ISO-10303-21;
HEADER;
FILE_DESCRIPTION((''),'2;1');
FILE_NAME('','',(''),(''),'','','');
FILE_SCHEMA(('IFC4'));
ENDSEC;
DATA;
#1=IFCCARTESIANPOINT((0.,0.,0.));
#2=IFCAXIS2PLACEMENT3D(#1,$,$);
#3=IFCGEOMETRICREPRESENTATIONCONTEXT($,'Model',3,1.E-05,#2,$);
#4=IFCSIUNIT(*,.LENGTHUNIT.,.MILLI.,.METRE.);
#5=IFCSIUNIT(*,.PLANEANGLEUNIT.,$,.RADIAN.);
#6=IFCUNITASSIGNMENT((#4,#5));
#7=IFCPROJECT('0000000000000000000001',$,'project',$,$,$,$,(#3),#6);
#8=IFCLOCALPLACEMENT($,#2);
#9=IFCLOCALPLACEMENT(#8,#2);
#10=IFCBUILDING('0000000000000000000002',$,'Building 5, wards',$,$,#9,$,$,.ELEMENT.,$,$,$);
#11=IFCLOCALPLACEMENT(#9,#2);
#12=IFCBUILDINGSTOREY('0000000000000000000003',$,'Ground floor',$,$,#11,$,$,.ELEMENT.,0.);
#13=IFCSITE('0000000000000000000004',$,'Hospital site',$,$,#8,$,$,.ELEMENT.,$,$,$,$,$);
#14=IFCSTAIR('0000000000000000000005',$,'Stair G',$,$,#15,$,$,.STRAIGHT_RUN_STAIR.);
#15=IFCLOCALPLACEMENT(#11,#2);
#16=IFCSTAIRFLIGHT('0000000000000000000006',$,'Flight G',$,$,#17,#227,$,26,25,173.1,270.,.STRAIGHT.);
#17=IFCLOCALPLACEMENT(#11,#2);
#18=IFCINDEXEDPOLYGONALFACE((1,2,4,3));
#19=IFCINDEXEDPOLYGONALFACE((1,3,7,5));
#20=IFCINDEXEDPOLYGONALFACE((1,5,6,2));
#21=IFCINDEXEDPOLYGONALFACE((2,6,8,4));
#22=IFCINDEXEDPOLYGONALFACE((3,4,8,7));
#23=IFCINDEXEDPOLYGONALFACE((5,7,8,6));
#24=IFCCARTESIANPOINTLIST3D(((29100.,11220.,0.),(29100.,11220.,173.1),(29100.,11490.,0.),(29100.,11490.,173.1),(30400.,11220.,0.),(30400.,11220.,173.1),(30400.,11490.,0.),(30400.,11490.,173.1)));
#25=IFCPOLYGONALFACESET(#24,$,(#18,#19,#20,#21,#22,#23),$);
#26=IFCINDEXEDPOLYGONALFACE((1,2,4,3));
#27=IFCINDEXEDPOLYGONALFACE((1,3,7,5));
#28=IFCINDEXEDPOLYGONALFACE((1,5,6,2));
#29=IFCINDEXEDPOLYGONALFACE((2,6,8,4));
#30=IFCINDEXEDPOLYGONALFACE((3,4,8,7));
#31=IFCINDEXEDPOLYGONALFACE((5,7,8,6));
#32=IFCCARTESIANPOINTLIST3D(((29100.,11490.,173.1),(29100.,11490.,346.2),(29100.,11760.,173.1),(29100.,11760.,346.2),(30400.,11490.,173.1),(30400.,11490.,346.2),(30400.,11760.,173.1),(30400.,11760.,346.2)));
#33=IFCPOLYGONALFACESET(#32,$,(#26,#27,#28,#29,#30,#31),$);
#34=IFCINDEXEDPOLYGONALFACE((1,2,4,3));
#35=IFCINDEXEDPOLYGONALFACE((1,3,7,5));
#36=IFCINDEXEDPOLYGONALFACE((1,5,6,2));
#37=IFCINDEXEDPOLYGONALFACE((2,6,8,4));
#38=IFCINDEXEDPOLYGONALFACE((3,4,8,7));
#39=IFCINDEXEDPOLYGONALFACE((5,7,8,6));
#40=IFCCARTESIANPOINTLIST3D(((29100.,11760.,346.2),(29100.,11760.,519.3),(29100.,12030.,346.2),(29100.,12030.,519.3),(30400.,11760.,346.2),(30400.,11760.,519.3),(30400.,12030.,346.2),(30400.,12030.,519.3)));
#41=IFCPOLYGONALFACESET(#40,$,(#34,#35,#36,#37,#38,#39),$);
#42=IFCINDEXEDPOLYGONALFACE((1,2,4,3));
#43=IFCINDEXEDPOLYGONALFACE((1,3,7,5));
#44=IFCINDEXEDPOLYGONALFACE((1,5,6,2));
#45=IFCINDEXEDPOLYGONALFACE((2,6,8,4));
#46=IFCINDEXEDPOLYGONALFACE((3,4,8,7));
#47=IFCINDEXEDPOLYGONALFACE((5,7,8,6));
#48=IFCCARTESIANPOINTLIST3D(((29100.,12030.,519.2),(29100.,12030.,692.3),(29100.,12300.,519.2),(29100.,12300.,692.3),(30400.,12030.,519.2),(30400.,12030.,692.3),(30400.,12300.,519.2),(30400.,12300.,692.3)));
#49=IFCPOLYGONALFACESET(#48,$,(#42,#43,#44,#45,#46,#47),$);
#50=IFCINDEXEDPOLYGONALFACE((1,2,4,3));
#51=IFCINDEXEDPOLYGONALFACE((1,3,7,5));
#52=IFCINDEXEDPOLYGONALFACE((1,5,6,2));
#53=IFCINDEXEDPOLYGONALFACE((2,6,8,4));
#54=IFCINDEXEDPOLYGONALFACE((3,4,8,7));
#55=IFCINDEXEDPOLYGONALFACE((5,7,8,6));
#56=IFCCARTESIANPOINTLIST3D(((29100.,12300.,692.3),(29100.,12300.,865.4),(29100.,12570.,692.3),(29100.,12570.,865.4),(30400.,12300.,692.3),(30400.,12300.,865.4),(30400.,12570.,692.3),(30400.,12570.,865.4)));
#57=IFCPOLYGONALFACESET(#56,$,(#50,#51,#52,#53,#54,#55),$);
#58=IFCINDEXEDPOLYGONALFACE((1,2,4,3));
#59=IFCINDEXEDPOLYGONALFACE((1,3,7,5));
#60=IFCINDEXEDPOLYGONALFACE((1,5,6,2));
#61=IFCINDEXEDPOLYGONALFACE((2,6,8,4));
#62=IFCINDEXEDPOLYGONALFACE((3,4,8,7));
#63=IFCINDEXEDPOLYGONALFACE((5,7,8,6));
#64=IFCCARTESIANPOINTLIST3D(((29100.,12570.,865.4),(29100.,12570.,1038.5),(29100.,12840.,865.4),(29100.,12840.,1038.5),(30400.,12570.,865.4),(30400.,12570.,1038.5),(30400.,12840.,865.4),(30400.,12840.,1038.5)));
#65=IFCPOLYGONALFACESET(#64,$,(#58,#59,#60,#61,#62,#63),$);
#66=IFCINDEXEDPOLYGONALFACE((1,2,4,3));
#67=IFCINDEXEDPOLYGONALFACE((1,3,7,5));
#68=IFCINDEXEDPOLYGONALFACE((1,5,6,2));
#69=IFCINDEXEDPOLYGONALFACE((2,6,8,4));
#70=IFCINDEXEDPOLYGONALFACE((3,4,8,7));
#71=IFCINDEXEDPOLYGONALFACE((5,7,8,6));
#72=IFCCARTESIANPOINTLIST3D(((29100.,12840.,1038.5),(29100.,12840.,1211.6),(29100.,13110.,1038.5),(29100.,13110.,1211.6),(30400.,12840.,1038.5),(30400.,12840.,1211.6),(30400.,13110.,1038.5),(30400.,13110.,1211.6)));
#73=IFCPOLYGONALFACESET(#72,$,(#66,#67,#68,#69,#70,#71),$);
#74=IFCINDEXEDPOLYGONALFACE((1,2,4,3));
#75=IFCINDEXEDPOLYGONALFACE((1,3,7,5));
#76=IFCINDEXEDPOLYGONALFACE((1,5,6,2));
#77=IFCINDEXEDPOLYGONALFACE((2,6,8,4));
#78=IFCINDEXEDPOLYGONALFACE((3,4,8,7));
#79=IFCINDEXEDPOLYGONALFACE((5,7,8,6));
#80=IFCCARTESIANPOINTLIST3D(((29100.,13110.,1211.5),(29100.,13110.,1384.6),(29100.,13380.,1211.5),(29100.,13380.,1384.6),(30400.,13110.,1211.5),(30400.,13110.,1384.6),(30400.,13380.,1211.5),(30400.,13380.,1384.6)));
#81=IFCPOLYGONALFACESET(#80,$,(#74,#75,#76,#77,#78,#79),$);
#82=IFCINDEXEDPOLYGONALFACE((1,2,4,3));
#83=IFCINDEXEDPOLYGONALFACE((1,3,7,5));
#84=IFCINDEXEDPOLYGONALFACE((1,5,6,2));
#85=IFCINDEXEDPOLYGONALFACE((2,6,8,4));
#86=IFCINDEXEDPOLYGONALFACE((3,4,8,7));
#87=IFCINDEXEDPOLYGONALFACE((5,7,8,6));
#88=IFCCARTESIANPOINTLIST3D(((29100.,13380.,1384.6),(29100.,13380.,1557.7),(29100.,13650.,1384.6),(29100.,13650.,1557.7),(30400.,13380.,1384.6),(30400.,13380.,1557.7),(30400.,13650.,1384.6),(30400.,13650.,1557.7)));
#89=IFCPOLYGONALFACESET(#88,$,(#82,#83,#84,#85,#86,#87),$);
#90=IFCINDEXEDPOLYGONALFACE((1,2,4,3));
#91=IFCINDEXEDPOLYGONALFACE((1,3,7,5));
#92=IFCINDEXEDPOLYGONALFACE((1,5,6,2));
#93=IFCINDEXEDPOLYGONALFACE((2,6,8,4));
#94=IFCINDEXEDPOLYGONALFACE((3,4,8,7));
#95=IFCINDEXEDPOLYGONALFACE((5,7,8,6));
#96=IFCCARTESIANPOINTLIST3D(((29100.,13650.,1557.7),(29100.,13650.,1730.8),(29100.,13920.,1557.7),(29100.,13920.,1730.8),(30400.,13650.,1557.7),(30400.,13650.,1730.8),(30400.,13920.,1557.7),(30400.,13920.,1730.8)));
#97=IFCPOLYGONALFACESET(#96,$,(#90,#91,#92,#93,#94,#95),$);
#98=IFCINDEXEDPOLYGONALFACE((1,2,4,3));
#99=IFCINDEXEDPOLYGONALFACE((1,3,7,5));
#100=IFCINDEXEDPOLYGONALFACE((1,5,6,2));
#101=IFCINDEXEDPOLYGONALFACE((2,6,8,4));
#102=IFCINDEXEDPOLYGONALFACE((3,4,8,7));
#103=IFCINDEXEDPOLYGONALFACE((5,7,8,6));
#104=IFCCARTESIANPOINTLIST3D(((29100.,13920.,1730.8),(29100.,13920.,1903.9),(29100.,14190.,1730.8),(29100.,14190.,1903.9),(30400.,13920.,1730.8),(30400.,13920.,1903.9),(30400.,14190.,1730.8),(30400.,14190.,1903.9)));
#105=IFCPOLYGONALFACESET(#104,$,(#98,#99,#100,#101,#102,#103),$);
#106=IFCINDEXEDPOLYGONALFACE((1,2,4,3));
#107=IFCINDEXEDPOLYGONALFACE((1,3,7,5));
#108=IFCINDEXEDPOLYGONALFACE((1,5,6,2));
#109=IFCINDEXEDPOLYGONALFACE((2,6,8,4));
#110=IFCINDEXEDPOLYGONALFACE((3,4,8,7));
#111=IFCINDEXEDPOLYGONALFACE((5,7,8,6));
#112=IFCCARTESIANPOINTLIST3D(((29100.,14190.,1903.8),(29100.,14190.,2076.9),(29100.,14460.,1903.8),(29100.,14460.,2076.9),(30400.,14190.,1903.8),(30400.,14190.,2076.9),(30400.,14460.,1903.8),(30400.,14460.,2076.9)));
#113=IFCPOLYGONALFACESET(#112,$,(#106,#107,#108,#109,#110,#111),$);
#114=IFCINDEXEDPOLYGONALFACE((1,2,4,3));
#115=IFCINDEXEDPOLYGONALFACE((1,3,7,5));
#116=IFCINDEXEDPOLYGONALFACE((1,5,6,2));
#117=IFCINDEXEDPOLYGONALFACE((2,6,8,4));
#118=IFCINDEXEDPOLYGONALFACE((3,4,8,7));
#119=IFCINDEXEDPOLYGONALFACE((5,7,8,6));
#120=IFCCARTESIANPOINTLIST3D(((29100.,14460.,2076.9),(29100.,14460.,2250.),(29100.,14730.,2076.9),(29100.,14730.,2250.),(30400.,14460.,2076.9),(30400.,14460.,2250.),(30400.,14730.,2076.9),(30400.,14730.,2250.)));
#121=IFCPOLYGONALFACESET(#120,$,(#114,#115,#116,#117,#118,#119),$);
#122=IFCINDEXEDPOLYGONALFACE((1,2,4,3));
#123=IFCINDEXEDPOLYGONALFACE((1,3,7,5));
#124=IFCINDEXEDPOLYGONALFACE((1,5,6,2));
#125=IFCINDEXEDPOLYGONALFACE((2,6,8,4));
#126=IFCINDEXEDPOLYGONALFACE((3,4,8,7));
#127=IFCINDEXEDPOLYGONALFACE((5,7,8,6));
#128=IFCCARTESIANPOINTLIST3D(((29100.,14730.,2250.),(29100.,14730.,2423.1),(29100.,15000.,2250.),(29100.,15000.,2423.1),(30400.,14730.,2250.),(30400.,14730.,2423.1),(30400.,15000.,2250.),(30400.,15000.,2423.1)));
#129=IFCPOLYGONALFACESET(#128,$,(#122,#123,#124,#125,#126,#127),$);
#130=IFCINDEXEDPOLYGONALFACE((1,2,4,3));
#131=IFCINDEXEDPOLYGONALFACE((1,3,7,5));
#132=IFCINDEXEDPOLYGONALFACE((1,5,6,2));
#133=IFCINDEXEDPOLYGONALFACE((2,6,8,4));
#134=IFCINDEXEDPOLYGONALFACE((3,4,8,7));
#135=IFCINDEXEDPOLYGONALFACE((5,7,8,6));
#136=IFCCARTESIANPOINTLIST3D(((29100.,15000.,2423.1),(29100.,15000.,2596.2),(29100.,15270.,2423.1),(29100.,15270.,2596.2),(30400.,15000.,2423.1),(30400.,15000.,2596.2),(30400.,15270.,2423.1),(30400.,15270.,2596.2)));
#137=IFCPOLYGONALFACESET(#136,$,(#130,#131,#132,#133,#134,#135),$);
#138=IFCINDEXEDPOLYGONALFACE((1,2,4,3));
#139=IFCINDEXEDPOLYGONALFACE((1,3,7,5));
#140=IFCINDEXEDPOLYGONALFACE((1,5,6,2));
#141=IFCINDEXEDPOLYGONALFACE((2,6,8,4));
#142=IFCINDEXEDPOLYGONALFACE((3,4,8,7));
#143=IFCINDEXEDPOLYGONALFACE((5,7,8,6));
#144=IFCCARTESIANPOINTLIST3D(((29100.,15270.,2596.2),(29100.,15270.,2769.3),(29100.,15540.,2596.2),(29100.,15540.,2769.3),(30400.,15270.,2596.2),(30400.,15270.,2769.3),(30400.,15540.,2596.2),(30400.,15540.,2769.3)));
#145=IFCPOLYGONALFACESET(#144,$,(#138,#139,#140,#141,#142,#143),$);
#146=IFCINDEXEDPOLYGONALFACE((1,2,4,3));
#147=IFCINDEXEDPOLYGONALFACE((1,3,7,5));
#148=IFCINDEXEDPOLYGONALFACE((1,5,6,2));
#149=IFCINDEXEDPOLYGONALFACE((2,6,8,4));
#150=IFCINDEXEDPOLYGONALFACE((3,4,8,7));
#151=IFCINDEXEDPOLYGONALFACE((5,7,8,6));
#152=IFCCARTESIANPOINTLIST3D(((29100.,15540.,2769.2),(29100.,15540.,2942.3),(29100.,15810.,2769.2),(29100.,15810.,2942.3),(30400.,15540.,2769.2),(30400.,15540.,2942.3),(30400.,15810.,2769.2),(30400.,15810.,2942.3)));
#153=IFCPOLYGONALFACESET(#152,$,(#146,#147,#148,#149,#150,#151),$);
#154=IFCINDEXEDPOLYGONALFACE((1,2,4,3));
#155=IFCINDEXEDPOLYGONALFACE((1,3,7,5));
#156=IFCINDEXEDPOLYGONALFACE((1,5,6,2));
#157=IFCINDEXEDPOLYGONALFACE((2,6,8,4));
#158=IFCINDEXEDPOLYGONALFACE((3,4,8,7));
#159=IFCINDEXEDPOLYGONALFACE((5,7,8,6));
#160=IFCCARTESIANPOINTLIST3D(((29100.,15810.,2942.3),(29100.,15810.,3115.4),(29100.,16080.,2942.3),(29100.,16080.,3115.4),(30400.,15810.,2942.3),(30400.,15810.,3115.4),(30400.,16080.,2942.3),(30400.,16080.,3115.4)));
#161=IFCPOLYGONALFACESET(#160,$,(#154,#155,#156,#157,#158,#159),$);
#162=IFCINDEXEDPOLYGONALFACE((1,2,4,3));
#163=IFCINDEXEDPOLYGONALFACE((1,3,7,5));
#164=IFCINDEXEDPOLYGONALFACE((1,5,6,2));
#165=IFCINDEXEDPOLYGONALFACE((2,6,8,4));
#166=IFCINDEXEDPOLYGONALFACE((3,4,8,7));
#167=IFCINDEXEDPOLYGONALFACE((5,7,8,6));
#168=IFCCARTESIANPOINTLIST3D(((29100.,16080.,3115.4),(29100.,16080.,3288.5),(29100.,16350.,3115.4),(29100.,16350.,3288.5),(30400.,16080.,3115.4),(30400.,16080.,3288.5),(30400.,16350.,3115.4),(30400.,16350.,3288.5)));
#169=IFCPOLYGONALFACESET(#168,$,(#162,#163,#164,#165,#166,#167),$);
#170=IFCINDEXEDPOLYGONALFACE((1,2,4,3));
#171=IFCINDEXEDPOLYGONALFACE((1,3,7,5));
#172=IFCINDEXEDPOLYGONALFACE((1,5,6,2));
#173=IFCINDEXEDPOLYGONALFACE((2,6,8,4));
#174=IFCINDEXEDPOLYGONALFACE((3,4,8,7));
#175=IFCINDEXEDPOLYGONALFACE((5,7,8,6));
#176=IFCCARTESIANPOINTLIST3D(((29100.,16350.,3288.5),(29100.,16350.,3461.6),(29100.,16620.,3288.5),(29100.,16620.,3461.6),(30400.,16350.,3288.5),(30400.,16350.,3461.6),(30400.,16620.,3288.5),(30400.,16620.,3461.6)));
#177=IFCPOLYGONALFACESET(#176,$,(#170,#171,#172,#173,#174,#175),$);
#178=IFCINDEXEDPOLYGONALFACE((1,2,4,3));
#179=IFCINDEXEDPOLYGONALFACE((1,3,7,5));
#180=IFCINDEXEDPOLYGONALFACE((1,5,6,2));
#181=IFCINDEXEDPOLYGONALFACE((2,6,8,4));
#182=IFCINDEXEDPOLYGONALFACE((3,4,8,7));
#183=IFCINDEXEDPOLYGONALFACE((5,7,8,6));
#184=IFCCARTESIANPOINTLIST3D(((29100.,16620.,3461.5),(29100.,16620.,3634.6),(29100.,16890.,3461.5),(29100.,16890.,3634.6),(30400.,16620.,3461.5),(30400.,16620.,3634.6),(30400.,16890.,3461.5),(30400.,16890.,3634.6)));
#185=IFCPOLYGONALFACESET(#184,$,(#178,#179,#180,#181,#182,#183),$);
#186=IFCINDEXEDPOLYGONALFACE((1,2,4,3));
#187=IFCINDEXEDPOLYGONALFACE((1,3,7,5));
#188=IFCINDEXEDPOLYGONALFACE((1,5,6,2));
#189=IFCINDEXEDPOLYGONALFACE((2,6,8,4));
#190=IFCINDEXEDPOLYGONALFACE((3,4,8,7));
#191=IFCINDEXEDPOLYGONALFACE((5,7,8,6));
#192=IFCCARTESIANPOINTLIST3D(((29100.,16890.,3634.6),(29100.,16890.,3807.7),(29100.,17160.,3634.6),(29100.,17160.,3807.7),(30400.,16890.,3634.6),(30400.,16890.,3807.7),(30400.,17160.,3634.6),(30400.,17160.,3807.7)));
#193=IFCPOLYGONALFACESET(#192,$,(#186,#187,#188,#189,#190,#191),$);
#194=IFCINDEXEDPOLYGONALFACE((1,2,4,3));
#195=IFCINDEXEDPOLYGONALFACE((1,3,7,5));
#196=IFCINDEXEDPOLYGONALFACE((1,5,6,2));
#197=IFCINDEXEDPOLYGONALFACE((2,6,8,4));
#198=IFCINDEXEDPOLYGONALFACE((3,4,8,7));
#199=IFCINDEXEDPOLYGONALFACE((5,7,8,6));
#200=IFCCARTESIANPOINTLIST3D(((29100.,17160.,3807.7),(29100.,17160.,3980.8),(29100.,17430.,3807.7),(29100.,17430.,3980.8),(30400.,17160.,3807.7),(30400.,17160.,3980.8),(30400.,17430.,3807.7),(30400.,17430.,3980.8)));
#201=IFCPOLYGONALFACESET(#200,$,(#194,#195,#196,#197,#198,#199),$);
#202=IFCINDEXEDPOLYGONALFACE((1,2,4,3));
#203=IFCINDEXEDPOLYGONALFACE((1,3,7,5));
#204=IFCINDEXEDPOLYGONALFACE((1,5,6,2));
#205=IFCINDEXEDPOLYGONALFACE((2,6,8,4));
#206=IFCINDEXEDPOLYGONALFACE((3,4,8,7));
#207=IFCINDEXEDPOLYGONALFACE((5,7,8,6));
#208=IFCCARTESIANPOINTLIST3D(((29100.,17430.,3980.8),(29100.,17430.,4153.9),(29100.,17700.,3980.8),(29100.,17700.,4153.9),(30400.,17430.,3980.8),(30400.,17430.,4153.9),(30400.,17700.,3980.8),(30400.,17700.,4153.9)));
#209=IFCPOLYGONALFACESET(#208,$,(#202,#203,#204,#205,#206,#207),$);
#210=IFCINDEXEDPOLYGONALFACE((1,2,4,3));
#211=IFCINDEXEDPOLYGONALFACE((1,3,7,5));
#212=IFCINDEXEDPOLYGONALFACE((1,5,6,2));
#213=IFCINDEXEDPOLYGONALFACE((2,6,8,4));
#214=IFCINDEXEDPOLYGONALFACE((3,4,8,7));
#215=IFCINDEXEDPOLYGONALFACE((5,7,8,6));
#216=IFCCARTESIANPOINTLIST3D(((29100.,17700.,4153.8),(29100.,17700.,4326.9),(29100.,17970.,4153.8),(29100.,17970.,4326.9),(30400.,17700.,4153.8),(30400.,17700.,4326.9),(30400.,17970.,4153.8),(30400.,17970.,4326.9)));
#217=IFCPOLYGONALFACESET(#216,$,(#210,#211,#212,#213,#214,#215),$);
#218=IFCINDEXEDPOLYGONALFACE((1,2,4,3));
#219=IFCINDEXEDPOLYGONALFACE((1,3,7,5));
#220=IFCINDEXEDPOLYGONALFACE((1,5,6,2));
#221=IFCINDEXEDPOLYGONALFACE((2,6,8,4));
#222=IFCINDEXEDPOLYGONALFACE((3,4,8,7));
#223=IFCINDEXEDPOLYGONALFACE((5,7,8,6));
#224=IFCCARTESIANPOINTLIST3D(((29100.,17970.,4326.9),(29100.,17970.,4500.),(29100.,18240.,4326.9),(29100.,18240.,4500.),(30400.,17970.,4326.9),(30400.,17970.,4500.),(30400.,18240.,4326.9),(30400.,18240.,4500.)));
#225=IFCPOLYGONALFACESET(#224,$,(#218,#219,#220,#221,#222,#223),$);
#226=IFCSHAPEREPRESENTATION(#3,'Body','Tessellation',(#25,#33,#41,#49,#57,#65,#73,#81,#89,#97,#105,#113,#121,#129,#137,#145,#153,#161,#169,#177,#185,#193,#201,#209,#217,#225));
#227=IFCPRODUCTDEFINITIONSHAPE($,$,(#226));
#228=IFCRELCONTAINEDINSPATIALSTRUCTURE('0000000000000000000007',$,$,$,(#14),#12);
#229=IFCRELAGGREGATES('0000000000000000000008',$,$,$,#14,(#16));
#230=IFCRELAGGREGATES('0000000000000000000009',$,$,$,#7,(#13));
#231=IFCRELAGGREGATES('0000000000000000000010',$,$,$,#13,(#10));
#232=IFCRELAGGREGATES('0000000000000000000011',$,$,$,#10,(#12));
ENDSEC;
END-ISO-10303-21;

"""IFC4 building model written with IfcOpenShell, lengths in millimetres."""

from ifc_helpers import new_model, si_unit, frame, frame_2d, origin, place, context, project, spatial, rectangle, extrude, element, aggregate, save


model = new_model("IFC4")

# Units and contexts
model_context = context("Model", 3, precision=1e-05, world=origin())
ifc_project = project(units=[si_unit("LENGTHUNIT", "METRE", prefix="MILLI"), si_unit("PLANEANGLEUNIT", "RADIAN")], contexts=[model_context])

# Site, building, storey
site_placement = place(None, origin())
site = spatial("IfcSite", under=ifc_project, at=site_placement, Name="Hospital site", CompositionType="ELEMENT")
building_placement = place(site_placement, origin())
building = spatial("IfcBuilding", under=site, at=building_placement, Name="Building 5, wards", CompositionType="ELEMENT")
storey_placement = place(building_placement, origin())
storey = spatial("IfcBuildingStorey", under=building, at=storey_placement, Name="Ground floor", CompositionType="ELEMENT", Elevation=0.0)

# Stair, stair flight
stair_placement = place(storey_placement, origin())
stair = element("IfcStair", 1, at=stair_placement, inside=storey, Name="Stair G", PredefinedType="STRAIGHT_RUN_STAIR")
stair_flight_placement = place(storey_placement, frame((29100.0, 11220.0, 0.0)))
stair_flight = element("IfcStairFlight", 2, at=stair_flight_placement, Name="Flight G", NumberOfRisers=26, NumberOfTreads=25, PredefinedType="STRAIGHT", RiserHeight=173.1, TreadLength=270.0, context=model_context, shape_type="SweptSolid", body=[
    extrude(rectangle(XDim=1300.0, YDim=270.0, at=frame_2d((650.0, 135.0))), origin(), (0.0, 0.0, 1.0), 173.1),
    extrude(rectangle(XDim=1300.0, YDim=270.0, at=frame_2d((650.0, 405.0))), frame((0.0, 0.0, 173.1)), (0.0, 0.0, 1.0), 173.1),
    extrude(rectangle(XDim=1300.0, YDim=270.0, at=frame_2d((650.0, 675.0))), frame((0.0, 0.0, 346.2)), (0.0, 0.0, 1.0), 173.1),
    extrude(rectangle(XDim=1300.0, YDim=270.0, at=frame_2d((650.0, 945.0))), frame((0.0, 0.0, 519.2)), (0.0, 0.0, 1.0), 173.1),
    extrude(rectangle(XDim=1300.0, YDim=270.0, at=frame_2d((650.0, 1215.0))), frame((0.0, 0.0, 692.3)), (0.0, 0.0, 1.0), 173.1),
    extrude(rectangle(XDim=1300.0, YDim=270.0, at=frame_2d((650.0, 1485.0))), frame((0.0, 0.0, 865.4)), (0.0, 0.0, 1.0), 173.1),
    extrude(rectangle(XDim=1300.0, YDim=270.0, at=frame_2d((650.0, 1755.0))), frame((0.0, 0.0, 1038.5)), (0.0, 0.0, 1.0), 173.1),
    extrude(rectangle(XDim=1300.0, YDim=270.0, at=frame_2d((650.0, 2025.0))), frame((0.0, 0.0, 1211.5)), (0.0, 0.0, 1.0), 173.1),
    extrude(rectangle(XDim=1300.0, YDim=270.0, at=frame_2d((650.0, 2295.0))), frame((0.0, 0.0, 1384.6)), (0.0, 0.0, 1.0), 173.1),
    extrude(rectangle(XDim=1300.0, YDim=270.0, at=frame_2d((650.0, 2565.0))), frame((0.0, 0.0, 1557.7)), (0.0, 0.0, 1.0), 173.1),
    extrude(rectangle(XDim=1300.0, YDim=270.0, at=frame_2d((650.0, 2835.0))), frame((0.0, 0.0, 1730.8)), (0.0, 0.0, 1.0), 173.1),
    extrude(rectangle(XDim=1300.0, YDim=270.0, at=frame_2d((650.0, 3105.0))), frame((0.0, 0.0, 1903.8)), (0.0, 0.0, 1.0), 173.1),
    extrude(rectangle(XDim=1300.0, YDim=270.0, at=frame_2d((650.0, 3375.0))), frame((0.0, 0.0, 2076.9)), (0.0, 0.0, 1.0), 173.1),
    extrude(rectangle(XDim=1300.0, YDim=270.0, at=frame_2d((650.0, 3645.0))), frame((0.0, 0.0, 2250.0)), (0.0, 0.0, 1.0), 173.1),
    extrude(rectangle(XDim=1300.0, YDim=270.0, at=frame_2d((650.0, 3915.0))), frame((0.0, 0.0, 2423.1)), (0.0, 0.0, 1.0), 173.1),
    extrude(rectangle(XDim=1300.0, YDim=270.0, at=frame_2d((650.0, 4185.0))), frame((0.0, 0.0, 2596.2)), (0.0, 0.0, 1.0), 173.1),
    extrude(rectangle(XDim=1300.0, YDim=270.0, at=frame_2d((650.0, 4455.0))), frame((0.0, 0.0, 2769.2)), (0.0, 0.0, 1.0), 173.1),
    extrude(rectangle(XDim=1300.0, YDim=270.0, at=frame_2d((650.0, 4725.0))), frame((0.0, 0.0, 2942.3)), (0.0, 0.0, 1.0), 173.1),
    extrude(rectangle(XDim=1300.0, YDim=270.0, at=frame_2d((650.0, 4995.0))), frame((0.0, 0.0, 3115.4)), (0.0, 0.0, 1.0), 173.1),
    extrude(rectangle(XDim=1300.0, YDim=270.0, at=frame_2d((650.0, 5265.0))), frame((0.0, 0.0, 3288.5)), (0.0, 0.0, 1.0), 173.1),
    extrude(rectangle(XDim=1300.0, YDim=270.0, at=frame_2d((650.0, 5535.0))), frame((0.0, 0.0, 3461.5)), (0.0, 0.0, 1.0), 173.1),
    extrude(rectangle(XDim=1300.0, YDim=270.0, at=frame_2d((650.0, 5805.0))), frame((0.0, 0.0, 3634.6)), (0.0, 0.0, 1.0), 173.1),
    extrude(rectangle(XDim=1300.0, YDim=270.0, at=frame_2d((650.0, 6075.0))), frame((0.0, 0.0, 3807.7)), (0.0, 0.0, 1.0), 173.1),
    extrude(rectangle(XDim=1300.0, YDim=270.0, at=frame_2d((650.0, 6345.0))), frame((0.0, 0.0, 3980.8)), (0.0, 0.0, 1.0), 173.1),
    extrude(rectangle(XDim=1300.0, YDim=270.0, at=frame_2d((650.0, 6615.0))), frame((0.0, 0.0, 4153.8)), (0.0, 0.0, 1.0), 173.1),
    extrude(rectangle(XDim=1300.0, YDim=270.0, at=frame_2d((650.0, 6885.0))), frame((0.0, 0.0, 4326.9)), (0.0, 0.0, 1.0), 173.1),
])
aggregate(stair, [stair_flight])

save(model, "model.ifc")
